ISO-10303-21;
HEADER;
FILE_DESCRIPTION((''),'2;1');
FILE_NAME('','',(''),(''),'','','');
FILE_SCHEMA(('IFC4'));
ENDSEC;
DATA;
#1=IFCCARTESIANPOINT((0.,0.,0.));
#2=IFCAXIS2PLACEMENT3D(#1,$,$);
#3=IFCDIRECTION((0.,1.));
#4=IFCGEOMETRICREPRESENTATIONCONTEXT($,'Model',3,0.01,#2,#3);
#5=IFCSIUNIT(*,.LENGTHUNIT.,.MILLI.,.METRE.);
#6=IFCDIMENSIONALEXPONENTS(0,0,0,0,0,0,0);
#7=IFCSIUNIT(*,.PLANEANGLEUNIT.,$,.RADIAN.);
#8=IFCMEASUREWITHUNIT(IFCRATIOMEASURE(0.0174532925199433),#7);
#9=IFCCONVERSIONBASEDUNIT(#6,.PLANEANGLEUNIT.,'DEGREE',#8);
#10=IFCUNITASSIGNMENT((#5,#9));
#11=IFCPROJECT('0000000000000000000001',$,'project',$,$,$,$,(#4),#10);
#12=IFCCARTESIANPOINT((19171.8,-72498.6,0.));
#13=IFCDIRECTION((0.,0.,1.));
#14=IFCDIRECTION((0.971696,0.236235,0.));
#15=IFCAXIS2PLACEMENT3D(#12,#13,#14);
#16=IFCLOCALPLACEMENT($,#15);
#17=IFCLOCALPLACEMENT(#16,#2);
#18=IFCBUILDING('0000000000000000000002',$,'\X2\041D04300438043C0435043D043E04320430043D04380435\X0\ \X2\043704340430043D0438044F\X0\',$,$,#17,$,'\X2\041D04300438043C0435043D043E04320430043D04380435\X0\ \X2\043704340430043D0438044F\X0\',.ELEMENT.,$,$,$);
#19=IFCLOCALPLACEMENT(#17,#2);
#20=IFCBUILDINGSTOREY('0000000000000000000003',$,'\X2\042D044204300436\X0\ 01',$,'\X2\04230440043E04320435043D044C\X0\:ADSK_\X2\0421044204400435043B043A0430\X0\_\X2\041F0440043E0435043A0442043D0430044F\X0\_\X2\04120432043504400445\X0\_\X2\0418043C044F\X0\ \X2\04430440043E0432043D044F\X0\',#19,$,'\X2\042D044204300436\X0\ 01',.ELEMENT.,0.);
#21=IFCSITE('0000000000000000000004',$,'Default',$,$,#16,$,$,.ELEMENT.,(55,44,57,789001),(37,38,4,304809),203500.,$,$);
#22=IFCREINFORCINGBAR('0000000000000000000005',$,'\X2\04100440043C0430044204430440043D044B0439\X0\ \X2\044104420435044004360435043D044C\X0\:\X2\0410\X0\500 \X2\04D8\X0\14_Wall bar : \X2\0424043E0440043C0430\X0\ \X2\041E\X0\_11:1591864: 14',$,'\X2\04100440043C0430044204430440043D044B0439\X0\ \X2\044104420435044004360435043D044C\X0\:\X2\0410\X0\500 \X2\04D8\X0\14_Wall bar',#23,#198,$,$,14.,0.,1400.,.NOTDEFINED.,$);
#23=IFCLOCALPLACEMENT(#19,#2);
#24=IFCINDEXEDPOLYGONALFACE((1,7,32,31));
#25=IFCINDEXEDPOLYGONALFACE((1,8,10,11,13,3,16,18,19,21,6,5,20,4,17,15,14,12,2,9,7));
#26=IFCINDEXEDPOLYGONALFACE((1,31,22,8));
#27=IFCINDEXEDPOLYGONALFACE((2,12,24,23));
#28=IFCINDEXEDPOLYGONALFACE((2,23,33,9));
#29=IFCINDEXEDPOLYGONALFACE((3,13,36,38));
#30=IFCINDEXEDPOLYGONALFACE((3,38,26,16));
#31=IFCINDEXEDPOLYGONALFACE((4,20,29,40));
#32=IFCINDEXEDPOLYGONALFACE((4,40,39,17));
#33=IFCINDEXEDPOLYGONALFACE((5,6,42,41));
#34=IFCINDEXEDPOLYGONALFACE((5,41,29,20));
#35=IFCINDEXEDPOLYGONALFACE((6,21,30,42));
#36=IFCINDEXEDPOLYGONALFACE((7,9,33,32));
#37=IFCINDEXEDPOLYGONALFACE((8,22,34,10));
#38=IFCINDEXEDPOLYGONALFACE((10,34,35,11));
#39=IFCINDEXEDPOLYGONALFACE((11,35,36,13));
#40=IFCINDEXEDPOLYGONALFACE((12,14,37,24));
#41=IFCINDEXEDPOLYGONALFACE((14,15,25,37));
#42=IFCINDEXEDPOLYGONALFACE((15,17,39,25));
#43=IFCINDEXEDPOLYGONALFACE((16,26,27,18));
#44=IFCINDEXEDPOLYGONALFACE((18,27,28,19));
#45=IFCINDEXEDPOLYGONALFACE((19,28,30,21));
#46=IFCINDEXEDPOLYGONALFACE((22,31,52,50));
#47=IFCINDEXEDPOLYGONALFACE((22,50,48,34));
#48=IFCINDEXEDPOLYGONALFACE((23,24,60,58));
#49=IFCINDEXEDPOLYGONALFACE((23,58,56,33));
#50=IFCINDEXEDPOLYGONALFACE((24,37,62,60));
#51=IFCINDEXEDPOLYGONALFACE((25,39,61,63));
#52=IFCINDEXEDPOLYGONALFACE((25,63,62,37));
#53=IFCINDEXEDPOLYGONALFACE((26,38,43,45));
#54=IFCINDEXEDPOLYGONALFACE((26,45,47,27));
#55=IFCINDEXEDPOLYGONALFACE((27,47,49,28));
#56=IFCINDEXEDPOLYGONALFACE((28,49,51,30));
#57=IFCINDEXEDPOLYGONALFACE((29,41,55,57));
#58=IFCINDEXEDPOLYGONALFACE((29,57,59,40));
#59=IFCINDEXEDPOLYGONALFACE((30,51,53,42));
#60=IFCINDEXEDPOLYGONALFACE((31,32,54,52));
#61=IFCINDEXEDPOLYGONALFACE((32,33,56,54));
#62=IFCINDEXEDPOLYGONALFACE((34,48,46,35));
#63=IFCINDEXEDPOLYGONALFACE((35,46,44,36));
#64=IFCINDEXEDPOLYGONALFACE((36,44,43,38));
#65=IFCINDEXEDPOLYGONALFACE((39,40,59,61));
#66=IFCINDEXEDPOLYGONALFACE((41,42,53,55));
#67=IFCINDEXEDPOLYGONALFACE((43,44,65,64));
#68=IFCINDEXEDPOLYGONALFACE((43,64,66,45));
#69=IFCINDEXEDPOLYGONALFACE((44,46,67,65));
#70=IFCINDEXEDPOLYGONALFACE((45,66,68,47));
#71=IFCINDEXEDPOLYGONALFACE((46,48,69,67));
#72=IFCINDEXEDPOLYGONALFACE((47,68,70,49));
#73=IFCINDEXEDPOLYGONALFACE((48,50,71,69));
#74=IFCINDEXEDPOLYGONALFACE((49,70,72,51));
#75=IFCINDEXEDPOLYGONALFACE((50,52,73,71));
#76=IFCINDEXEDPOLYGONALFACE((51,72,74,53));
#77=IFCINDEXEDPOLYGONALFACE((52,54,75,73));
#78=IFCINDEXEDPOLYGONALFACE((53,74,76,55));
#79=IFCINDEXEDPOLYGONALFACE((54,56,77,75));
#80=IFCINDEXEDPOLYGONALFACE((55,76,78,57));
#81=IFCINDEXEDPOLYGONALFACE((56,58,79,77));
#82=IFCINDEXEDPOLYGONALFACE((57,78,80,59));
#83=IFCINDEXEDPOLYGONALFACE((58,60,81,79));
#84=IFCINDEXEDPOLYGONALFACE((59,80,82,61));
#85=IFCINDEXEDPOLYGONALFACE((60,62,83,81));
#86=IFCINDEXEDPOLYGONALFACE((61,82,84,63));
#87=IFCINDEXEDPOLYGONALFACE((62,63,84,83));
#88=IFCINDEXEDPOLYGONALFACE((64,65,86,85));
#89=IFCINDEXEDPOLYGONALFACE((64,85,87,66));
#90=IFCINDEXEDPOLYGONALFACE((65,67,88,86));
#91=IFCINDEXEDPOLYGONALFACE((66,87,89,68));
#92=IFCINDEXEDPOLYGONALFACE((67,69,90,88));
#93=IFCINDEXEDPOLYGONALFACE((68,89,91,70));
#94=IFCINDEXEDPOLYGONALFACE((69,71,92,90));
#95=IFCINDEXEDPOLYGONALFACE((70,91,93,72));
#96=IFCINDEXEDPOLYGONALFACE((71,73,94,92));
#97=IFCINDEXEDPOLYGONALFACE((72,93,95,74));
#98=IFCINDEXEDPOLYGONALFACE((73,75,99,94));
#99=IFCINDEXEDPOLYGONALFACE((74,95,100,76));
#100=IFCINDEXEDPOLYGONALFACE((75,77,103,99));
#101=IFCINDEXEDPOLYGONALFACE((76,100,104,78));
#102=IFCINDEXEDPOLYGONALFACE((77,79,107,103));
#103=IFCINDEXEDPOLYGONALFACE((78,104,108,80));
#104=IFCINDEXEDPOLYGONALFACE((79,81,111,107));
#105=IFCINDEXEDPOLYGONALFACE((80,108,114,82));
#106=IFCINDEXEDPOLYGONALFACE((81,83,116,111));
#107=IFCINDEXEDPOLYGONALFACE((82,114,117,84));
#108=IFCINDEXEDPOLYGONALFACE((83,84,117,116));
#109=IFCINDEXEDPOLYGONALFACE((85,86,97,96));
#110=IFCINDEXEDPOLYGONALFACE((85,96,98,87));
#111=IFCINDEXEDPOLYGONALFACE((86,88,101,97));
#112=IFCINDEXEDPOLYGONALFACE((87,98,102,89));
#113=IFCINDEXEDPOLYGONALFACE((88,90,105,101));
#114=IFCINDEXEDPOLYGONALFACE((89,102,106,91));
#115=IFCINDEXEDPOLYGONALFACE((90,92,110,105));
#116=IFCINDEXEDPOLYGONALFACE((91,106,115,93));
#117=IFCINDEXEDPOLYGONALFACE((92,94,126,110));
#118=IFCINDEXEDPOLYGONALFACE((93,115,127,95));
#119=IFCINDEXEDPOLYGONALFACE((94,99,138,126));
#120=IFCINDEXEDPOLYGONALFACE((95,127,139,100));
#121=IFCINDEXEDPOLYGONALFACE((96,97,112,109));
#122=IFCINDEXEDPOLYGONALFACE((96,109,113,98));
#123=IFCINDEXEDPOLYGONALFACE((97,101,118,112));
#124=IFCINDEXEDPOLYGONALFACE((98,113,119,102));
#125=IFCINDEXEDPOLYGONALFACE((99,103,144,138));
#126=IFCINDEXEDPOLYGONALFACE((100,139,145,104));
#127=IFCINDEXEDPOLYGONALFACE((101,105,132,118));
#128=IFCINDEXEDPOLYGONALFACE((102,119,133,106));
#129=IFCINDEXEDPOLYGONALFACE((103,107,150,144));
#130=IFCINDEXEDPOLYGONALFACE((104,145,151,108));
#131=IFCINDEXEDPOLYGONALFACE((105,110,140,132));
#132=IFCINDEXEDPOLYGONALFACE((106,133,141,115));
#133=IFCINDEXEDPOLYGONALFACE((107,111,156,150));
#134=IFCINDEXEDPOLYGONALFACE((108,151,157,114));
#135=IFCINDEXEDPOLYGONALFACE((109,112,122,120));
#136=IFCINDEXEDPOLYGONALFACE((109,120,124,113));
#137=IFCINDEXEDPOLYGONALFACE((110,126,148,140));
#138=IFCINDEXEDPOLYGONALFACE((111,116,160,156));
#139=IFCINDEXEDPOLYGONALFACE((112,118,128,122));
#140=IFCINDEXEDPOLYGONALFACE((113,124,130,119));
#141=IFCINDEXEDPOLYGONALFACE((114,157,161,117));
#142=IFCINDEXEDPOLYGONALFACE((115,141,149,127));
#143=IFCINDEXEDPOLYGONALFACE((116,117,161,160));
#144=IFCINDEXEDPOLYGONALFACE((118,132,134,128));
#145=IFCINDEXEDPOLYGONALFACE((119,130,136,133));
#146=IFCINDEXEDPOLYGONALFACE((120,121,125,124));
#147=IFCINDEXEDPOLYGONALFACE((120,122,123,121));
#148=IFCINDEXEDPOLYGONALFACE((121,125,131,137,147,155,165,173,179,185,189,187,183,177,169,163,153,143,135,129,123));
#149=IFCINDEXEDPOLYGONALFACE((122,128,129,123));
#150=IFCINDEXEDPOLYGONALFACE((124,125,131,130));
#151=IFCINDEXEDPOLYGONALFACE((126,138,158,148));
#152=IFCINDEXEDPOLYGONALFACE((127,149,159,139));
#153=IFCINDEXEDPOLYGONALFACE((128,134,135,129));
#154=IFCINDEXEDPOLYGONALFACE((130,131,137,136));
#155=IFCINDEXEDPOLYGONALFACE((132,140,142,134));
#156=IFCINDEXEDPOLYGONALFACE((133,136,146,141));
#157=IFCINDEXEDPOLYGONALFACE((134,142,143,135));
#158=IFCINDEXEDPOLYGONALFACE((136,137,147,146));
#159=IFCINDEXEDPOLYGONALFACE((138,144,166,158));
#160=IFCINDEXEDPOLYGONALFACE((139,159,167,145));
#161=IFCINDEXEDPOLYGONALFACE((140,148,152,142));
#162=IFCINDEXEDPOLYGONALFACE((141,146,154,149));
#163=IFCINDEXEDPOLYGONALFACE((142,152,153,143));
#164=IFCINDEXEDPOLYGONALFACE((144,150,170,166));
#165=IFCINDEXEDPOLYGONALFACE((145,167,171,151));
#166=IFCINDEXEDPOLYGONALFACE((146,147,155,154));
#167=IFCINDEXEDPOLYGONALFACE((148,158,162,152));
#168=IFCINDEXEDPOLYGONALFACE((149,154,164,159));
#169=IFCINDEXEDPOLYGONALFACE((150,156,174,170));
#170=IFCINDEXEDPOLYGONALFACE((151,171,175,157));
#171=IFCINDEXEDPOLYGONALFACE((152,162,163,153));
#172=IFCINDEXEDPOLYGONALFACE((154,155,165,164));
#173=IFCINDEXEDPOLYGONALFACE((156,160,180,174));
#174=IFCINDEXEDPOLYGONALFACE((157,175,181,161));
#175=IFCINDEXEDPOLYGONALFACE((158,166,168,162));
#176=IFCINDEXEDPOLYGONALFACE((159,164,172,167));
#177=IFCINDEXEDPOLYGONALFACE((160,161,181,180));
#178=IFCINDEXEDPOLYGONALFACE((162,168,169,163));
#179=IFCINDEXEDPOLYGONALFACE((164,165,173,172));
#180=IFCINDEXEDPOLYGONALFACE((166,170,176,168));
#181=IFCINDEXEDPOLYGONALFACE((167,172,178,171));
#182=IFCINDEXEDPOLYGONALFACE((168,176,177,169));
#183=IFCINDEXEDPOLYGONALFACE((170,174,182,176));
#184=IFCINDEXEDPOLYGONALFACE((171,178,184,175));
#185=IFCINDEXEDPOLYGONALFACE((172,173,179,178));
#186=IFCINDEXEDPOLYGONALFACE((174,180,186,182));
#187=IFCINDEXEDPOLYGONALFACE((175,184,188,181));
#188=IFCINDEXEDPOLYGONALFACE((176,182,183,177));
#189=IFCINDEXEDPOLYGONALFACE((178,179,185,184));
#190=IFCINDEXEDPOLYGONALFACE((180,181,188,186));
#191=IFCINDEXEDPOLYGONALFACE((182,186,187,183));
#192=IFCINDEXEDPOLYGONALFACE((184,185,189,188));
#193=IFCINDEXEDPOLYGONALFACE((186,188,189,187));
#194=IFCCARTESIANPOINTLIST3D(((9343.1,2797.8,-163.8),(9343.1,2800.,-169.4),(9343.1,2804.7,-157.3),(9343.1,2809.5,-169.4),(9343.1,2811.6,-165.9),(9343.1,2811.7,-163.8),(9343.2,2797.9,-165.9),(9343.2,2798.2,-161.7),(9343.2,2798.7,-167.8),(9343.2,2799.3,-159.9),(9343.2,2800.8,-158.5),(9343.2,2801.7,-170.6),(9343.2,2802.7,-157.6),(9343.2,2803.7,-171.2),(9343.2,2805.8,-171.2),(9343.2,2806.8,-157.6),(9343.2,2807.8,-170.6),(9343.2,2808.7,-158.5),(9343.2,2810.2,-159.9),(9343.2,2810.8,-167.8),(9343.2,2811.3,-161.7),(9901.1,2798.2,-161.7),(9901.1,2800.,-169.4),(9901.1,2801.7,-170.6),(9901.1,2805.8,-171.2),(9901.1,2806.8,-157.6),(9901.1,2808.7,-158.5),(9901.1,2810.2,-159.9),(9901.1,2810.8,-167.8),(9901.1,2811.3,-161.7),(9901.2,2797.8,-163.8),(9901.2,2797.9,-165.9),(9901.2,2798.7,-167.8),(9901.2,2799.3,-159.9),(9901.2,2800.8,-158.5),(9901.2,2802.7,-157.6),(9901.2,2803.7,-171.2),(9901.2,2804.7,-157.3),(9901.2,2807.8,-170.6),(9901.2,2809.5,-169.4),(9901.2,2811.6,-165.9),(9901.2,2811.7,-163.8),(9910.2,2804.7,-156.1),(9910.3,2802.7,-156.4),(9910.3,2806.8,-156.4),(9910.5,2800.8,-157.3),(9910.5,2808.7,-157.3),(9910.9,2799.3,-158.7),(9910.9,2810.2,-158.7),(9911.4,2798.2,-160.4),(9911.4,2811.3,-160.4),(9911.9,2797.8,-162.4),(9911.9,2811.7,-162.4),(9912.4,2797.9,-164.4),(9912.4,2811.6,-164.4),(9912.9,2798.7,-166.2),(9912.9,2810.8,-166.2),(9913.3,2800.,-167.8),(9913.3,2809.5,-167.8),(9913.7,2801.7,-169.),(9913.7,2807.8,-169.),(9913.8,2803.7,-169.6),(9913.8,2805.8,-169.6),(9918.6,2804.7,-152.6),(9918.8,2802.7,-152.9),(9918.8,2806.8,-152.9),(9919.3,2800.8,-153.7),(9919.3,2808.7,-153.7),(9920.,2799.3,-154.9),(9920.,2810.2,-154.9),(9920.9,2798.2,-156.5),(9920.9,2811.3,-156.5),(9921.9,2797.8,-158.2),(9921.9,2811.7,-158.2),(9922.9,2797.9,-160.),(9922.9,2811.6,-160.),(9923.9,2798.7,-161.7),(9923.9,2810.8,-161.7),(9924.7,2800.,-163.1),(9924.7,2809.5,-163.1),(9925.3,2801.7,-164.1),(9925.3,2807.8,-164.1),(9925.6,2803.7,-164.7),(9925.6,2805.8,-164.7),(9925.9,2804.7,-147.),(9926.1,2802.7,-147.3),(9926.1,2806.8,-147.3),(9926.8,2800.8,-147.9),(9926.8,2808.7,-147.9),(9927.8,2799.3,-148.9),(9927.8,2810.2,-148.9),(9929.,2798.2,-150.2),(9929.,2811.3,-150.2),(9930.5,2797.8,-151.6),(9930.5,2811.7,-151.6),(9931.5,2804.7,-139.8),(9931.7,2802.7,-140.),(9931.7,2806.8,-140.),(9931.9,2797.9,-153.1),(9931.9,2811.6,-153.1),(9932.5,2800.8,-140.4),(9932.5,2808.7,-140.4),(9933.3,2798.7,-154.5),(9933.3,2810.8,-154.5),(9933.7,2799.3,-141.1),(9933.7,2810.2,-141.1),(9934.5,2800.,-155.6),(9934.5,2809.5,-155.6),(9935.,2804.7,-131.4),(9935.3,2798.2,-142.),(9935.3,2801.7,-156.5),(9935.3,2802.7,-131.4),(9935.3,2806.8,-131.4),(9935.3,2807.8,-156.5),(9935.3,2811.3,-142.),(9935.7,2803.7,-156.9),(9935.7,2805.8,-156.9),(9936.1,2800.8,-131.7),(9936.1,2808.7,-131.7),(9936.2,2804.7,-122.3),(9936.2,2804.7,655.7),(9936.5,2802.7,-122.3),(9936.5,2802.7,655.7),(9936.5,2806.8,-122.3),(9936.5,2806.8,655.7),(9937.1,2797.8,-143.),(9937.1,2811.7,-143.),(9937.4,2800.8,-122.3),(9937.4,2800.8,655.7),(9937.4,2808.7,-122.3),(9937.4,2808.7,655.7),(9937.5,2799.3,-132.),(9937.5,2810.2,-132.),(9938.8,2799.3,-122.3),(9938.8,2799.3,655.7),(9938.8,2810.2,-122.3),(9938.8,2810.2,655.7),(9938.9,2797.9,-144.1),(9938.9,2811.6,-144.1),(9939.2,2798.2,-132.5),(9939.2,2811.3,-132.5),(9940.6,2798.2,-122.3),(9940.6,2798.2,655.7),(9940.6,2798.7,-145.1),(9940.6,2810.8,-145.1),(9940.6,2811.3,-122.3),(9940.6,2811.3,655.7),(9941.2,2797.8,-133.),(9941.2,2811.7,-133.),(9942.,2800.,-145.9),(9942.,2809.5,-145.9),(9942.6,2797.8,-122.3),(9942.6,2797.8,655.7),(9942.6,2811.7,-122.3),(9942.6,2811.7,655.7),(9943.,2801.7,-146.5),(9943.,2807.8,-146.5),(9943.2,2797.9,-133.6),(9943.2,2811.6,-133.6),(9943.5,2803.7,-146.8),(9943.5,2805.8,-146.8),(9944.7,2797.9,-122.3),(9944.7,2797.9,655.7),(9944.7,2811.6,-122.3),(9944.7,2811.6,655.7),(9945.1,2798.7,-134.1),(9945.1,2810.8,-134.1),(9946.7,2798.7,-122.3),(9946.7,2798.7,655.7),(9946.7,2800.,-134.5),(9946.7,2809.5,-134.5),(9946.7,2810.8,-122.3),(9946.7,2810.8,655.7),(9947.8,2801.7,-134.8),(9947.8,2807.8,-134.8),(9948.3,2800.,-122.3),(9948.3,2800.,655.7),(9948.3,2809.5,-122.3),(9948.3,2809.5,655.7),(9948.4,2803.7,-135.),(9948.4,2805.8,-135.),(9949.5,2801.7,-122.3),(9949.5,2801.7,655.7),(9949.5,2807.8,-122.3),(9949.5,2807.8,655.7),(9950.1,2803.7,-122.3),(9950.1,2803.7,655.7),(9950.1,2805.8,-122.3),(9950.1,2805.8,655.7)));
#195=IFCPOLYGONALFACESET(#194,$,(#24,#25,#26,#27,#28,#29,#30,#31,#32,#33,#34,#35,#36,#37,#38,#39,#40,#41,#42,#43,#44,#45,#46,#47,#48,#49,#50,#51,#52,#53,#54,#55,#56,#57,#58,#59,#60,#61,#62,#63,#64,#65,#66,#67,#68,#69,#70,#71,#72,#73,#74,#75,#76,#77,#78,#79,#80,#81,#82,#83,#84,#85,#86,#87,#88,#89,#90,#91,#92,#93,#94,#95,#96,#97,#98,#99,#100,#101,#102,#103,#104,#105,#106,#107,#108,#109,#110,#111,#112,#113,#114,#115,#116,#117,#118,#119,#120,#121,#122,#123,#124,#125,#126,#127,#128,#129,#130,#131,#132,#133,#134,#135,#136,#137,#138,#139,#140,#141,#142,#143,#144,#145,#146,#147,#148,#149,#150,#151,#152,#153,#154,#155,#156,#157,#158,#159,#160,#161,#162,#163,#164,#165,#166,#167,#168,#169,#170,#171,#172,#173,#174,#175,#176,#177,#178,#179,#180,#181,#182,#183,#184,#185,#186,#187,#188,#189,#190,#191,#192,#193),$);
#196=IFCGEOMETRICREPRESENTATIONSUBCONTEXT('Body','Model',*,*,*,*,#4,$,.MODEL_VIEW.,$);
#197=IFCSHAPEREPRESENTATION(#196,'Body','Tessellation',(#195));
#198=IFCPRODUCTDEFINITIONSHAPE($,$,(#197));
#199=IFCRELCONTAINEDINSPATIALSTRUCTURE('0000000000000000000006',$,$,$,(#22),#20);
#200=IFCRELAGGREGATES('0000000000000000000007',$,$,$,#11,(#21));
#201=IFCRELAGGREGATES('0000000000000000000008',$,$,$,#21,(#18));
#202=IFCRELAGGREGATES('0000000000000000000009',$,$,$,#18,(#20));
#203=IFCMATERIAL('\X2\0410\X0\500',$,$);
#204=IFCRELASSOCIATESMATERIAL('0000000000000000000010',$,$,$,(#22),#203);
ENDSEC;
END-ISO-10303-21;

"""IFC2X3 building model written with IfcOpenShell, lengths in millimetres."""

from ifc_helpers import new_model, entity, si_unit, converted_unit, direction, frame, origin, place, context, subcontext, project, spatial, material, element, save


model = new_model("IFC2X3")

# Units and contexts
model_context = context("Model", 3, precision=0.01, world=origin(), true_north=direction((0.0, 1.0)))
body_context = subcontext(model_context, "Body", "Model", "MODEL_VIEW")
ifc_project = project(units=[si_unit("LENGTHUNIT", "METRE", prefix="MILLI"), converted_unit("PLANEANGLEUNIT", "DEGREE", entity("IfcRatioMeasure", 0.0174532925199433), si_unit("PLANEANGLEUNIT", "RADIAN"), dimensions=[0, 0, 0, 0, 0, 0, 0])], contexts=[model_context])

# Site, building, storey
site_placement = place(None, frame((19171.8, -72498.6, 0.0), z_axis=(0.0, 0.0, 1.0), x_axis=(0.971696, 0.236235, 0.0)))
site = spatial("IfcSite", under=ifc_project, at=site_placement, Name="Default", CompositionType="ELEMENT", RefLatitude=(55, 44, 57, 789001), RefLongitude=(37, 38, 4, 304809), RefElevation=203500.0)
building_placement = place(site_placement, origin())
building = spatial("IfcBuilding", under=site, at=building_placement, Name="Наименование здания", LongName="Наименование здания", CompositionType="ELEMENT")
storey_placement = place(building_placement, origin())
storey = spatial("IfcBuildingStorey", under=building, at=storey_placement, Name="Этаж 01", ObjectType="Уровень:ADSK_Стрелка_Проектная_Вверх_Имя уровня", LongName="Этаж 01", CompositionType="ELEMENT", Elevation=0.0)

# Reinforcing bar
ifc_material = material(Name="А500")
placement = place(storey_placement, origin())
element("IfcReinforcingBar", 1, at=placement, inside=storey, material=ifc_material, Name="Арматурный стержень:А500 Ә14_Wall bar : Форма О_11:1591864: 14", ObjectType="Арматурный стержень:А500 Ә14_Wall bar", BarLength=1400.0, BarRole="NOTDEFINED", CrossSectionArea=0.0, NominalDiameter=14.0, context=body_context, shape_type="AdvancedSweptSolid", body=[
    entity("IfcSweptDiskSolid", entity("IfcCompositeCurve", [entity("IfcCompositeCurveSegment", "CONTINUOUS", True, entity("IfcPolyline", [entity("IfcCartesianPoint", [9943.1, 2804.7, 655.7]), entity("IfcCartesianPoint", [9943.1, 2804.7, -122.3])])), entity("IfcCompositeCurveSegment", "CONTINUOUS", True, entity("IfcTrimmedCurve", entity("IfcCircle", entity("IfcAxis2Placement3D", entity("IfcCartesianPoint", [9901.1, 2804.7, -122.3]), entity("IfcDirection", [0.0, 1.0, 0.0]), entity("IfcDirection", [0.0, 0.0, -1.0])), 42.0), [entity("IfcParameterValue", 270.0)], [entity("IfcParameterValue", 360.0)], True, "PARAMETER")), entity("IfcCompositeCurveSegment", "CONTINUOUS", True, entity("IfcPolyline", [entity("IfcCartesianPoint", [9901.1, 2804.7, -164.3]), entity("IfcCartesianPoint", [9343.1, 2804.7, -164.3])]))], False), 7.0, None, 0.0, 92.0),
])

save(model, "model.ifc")
